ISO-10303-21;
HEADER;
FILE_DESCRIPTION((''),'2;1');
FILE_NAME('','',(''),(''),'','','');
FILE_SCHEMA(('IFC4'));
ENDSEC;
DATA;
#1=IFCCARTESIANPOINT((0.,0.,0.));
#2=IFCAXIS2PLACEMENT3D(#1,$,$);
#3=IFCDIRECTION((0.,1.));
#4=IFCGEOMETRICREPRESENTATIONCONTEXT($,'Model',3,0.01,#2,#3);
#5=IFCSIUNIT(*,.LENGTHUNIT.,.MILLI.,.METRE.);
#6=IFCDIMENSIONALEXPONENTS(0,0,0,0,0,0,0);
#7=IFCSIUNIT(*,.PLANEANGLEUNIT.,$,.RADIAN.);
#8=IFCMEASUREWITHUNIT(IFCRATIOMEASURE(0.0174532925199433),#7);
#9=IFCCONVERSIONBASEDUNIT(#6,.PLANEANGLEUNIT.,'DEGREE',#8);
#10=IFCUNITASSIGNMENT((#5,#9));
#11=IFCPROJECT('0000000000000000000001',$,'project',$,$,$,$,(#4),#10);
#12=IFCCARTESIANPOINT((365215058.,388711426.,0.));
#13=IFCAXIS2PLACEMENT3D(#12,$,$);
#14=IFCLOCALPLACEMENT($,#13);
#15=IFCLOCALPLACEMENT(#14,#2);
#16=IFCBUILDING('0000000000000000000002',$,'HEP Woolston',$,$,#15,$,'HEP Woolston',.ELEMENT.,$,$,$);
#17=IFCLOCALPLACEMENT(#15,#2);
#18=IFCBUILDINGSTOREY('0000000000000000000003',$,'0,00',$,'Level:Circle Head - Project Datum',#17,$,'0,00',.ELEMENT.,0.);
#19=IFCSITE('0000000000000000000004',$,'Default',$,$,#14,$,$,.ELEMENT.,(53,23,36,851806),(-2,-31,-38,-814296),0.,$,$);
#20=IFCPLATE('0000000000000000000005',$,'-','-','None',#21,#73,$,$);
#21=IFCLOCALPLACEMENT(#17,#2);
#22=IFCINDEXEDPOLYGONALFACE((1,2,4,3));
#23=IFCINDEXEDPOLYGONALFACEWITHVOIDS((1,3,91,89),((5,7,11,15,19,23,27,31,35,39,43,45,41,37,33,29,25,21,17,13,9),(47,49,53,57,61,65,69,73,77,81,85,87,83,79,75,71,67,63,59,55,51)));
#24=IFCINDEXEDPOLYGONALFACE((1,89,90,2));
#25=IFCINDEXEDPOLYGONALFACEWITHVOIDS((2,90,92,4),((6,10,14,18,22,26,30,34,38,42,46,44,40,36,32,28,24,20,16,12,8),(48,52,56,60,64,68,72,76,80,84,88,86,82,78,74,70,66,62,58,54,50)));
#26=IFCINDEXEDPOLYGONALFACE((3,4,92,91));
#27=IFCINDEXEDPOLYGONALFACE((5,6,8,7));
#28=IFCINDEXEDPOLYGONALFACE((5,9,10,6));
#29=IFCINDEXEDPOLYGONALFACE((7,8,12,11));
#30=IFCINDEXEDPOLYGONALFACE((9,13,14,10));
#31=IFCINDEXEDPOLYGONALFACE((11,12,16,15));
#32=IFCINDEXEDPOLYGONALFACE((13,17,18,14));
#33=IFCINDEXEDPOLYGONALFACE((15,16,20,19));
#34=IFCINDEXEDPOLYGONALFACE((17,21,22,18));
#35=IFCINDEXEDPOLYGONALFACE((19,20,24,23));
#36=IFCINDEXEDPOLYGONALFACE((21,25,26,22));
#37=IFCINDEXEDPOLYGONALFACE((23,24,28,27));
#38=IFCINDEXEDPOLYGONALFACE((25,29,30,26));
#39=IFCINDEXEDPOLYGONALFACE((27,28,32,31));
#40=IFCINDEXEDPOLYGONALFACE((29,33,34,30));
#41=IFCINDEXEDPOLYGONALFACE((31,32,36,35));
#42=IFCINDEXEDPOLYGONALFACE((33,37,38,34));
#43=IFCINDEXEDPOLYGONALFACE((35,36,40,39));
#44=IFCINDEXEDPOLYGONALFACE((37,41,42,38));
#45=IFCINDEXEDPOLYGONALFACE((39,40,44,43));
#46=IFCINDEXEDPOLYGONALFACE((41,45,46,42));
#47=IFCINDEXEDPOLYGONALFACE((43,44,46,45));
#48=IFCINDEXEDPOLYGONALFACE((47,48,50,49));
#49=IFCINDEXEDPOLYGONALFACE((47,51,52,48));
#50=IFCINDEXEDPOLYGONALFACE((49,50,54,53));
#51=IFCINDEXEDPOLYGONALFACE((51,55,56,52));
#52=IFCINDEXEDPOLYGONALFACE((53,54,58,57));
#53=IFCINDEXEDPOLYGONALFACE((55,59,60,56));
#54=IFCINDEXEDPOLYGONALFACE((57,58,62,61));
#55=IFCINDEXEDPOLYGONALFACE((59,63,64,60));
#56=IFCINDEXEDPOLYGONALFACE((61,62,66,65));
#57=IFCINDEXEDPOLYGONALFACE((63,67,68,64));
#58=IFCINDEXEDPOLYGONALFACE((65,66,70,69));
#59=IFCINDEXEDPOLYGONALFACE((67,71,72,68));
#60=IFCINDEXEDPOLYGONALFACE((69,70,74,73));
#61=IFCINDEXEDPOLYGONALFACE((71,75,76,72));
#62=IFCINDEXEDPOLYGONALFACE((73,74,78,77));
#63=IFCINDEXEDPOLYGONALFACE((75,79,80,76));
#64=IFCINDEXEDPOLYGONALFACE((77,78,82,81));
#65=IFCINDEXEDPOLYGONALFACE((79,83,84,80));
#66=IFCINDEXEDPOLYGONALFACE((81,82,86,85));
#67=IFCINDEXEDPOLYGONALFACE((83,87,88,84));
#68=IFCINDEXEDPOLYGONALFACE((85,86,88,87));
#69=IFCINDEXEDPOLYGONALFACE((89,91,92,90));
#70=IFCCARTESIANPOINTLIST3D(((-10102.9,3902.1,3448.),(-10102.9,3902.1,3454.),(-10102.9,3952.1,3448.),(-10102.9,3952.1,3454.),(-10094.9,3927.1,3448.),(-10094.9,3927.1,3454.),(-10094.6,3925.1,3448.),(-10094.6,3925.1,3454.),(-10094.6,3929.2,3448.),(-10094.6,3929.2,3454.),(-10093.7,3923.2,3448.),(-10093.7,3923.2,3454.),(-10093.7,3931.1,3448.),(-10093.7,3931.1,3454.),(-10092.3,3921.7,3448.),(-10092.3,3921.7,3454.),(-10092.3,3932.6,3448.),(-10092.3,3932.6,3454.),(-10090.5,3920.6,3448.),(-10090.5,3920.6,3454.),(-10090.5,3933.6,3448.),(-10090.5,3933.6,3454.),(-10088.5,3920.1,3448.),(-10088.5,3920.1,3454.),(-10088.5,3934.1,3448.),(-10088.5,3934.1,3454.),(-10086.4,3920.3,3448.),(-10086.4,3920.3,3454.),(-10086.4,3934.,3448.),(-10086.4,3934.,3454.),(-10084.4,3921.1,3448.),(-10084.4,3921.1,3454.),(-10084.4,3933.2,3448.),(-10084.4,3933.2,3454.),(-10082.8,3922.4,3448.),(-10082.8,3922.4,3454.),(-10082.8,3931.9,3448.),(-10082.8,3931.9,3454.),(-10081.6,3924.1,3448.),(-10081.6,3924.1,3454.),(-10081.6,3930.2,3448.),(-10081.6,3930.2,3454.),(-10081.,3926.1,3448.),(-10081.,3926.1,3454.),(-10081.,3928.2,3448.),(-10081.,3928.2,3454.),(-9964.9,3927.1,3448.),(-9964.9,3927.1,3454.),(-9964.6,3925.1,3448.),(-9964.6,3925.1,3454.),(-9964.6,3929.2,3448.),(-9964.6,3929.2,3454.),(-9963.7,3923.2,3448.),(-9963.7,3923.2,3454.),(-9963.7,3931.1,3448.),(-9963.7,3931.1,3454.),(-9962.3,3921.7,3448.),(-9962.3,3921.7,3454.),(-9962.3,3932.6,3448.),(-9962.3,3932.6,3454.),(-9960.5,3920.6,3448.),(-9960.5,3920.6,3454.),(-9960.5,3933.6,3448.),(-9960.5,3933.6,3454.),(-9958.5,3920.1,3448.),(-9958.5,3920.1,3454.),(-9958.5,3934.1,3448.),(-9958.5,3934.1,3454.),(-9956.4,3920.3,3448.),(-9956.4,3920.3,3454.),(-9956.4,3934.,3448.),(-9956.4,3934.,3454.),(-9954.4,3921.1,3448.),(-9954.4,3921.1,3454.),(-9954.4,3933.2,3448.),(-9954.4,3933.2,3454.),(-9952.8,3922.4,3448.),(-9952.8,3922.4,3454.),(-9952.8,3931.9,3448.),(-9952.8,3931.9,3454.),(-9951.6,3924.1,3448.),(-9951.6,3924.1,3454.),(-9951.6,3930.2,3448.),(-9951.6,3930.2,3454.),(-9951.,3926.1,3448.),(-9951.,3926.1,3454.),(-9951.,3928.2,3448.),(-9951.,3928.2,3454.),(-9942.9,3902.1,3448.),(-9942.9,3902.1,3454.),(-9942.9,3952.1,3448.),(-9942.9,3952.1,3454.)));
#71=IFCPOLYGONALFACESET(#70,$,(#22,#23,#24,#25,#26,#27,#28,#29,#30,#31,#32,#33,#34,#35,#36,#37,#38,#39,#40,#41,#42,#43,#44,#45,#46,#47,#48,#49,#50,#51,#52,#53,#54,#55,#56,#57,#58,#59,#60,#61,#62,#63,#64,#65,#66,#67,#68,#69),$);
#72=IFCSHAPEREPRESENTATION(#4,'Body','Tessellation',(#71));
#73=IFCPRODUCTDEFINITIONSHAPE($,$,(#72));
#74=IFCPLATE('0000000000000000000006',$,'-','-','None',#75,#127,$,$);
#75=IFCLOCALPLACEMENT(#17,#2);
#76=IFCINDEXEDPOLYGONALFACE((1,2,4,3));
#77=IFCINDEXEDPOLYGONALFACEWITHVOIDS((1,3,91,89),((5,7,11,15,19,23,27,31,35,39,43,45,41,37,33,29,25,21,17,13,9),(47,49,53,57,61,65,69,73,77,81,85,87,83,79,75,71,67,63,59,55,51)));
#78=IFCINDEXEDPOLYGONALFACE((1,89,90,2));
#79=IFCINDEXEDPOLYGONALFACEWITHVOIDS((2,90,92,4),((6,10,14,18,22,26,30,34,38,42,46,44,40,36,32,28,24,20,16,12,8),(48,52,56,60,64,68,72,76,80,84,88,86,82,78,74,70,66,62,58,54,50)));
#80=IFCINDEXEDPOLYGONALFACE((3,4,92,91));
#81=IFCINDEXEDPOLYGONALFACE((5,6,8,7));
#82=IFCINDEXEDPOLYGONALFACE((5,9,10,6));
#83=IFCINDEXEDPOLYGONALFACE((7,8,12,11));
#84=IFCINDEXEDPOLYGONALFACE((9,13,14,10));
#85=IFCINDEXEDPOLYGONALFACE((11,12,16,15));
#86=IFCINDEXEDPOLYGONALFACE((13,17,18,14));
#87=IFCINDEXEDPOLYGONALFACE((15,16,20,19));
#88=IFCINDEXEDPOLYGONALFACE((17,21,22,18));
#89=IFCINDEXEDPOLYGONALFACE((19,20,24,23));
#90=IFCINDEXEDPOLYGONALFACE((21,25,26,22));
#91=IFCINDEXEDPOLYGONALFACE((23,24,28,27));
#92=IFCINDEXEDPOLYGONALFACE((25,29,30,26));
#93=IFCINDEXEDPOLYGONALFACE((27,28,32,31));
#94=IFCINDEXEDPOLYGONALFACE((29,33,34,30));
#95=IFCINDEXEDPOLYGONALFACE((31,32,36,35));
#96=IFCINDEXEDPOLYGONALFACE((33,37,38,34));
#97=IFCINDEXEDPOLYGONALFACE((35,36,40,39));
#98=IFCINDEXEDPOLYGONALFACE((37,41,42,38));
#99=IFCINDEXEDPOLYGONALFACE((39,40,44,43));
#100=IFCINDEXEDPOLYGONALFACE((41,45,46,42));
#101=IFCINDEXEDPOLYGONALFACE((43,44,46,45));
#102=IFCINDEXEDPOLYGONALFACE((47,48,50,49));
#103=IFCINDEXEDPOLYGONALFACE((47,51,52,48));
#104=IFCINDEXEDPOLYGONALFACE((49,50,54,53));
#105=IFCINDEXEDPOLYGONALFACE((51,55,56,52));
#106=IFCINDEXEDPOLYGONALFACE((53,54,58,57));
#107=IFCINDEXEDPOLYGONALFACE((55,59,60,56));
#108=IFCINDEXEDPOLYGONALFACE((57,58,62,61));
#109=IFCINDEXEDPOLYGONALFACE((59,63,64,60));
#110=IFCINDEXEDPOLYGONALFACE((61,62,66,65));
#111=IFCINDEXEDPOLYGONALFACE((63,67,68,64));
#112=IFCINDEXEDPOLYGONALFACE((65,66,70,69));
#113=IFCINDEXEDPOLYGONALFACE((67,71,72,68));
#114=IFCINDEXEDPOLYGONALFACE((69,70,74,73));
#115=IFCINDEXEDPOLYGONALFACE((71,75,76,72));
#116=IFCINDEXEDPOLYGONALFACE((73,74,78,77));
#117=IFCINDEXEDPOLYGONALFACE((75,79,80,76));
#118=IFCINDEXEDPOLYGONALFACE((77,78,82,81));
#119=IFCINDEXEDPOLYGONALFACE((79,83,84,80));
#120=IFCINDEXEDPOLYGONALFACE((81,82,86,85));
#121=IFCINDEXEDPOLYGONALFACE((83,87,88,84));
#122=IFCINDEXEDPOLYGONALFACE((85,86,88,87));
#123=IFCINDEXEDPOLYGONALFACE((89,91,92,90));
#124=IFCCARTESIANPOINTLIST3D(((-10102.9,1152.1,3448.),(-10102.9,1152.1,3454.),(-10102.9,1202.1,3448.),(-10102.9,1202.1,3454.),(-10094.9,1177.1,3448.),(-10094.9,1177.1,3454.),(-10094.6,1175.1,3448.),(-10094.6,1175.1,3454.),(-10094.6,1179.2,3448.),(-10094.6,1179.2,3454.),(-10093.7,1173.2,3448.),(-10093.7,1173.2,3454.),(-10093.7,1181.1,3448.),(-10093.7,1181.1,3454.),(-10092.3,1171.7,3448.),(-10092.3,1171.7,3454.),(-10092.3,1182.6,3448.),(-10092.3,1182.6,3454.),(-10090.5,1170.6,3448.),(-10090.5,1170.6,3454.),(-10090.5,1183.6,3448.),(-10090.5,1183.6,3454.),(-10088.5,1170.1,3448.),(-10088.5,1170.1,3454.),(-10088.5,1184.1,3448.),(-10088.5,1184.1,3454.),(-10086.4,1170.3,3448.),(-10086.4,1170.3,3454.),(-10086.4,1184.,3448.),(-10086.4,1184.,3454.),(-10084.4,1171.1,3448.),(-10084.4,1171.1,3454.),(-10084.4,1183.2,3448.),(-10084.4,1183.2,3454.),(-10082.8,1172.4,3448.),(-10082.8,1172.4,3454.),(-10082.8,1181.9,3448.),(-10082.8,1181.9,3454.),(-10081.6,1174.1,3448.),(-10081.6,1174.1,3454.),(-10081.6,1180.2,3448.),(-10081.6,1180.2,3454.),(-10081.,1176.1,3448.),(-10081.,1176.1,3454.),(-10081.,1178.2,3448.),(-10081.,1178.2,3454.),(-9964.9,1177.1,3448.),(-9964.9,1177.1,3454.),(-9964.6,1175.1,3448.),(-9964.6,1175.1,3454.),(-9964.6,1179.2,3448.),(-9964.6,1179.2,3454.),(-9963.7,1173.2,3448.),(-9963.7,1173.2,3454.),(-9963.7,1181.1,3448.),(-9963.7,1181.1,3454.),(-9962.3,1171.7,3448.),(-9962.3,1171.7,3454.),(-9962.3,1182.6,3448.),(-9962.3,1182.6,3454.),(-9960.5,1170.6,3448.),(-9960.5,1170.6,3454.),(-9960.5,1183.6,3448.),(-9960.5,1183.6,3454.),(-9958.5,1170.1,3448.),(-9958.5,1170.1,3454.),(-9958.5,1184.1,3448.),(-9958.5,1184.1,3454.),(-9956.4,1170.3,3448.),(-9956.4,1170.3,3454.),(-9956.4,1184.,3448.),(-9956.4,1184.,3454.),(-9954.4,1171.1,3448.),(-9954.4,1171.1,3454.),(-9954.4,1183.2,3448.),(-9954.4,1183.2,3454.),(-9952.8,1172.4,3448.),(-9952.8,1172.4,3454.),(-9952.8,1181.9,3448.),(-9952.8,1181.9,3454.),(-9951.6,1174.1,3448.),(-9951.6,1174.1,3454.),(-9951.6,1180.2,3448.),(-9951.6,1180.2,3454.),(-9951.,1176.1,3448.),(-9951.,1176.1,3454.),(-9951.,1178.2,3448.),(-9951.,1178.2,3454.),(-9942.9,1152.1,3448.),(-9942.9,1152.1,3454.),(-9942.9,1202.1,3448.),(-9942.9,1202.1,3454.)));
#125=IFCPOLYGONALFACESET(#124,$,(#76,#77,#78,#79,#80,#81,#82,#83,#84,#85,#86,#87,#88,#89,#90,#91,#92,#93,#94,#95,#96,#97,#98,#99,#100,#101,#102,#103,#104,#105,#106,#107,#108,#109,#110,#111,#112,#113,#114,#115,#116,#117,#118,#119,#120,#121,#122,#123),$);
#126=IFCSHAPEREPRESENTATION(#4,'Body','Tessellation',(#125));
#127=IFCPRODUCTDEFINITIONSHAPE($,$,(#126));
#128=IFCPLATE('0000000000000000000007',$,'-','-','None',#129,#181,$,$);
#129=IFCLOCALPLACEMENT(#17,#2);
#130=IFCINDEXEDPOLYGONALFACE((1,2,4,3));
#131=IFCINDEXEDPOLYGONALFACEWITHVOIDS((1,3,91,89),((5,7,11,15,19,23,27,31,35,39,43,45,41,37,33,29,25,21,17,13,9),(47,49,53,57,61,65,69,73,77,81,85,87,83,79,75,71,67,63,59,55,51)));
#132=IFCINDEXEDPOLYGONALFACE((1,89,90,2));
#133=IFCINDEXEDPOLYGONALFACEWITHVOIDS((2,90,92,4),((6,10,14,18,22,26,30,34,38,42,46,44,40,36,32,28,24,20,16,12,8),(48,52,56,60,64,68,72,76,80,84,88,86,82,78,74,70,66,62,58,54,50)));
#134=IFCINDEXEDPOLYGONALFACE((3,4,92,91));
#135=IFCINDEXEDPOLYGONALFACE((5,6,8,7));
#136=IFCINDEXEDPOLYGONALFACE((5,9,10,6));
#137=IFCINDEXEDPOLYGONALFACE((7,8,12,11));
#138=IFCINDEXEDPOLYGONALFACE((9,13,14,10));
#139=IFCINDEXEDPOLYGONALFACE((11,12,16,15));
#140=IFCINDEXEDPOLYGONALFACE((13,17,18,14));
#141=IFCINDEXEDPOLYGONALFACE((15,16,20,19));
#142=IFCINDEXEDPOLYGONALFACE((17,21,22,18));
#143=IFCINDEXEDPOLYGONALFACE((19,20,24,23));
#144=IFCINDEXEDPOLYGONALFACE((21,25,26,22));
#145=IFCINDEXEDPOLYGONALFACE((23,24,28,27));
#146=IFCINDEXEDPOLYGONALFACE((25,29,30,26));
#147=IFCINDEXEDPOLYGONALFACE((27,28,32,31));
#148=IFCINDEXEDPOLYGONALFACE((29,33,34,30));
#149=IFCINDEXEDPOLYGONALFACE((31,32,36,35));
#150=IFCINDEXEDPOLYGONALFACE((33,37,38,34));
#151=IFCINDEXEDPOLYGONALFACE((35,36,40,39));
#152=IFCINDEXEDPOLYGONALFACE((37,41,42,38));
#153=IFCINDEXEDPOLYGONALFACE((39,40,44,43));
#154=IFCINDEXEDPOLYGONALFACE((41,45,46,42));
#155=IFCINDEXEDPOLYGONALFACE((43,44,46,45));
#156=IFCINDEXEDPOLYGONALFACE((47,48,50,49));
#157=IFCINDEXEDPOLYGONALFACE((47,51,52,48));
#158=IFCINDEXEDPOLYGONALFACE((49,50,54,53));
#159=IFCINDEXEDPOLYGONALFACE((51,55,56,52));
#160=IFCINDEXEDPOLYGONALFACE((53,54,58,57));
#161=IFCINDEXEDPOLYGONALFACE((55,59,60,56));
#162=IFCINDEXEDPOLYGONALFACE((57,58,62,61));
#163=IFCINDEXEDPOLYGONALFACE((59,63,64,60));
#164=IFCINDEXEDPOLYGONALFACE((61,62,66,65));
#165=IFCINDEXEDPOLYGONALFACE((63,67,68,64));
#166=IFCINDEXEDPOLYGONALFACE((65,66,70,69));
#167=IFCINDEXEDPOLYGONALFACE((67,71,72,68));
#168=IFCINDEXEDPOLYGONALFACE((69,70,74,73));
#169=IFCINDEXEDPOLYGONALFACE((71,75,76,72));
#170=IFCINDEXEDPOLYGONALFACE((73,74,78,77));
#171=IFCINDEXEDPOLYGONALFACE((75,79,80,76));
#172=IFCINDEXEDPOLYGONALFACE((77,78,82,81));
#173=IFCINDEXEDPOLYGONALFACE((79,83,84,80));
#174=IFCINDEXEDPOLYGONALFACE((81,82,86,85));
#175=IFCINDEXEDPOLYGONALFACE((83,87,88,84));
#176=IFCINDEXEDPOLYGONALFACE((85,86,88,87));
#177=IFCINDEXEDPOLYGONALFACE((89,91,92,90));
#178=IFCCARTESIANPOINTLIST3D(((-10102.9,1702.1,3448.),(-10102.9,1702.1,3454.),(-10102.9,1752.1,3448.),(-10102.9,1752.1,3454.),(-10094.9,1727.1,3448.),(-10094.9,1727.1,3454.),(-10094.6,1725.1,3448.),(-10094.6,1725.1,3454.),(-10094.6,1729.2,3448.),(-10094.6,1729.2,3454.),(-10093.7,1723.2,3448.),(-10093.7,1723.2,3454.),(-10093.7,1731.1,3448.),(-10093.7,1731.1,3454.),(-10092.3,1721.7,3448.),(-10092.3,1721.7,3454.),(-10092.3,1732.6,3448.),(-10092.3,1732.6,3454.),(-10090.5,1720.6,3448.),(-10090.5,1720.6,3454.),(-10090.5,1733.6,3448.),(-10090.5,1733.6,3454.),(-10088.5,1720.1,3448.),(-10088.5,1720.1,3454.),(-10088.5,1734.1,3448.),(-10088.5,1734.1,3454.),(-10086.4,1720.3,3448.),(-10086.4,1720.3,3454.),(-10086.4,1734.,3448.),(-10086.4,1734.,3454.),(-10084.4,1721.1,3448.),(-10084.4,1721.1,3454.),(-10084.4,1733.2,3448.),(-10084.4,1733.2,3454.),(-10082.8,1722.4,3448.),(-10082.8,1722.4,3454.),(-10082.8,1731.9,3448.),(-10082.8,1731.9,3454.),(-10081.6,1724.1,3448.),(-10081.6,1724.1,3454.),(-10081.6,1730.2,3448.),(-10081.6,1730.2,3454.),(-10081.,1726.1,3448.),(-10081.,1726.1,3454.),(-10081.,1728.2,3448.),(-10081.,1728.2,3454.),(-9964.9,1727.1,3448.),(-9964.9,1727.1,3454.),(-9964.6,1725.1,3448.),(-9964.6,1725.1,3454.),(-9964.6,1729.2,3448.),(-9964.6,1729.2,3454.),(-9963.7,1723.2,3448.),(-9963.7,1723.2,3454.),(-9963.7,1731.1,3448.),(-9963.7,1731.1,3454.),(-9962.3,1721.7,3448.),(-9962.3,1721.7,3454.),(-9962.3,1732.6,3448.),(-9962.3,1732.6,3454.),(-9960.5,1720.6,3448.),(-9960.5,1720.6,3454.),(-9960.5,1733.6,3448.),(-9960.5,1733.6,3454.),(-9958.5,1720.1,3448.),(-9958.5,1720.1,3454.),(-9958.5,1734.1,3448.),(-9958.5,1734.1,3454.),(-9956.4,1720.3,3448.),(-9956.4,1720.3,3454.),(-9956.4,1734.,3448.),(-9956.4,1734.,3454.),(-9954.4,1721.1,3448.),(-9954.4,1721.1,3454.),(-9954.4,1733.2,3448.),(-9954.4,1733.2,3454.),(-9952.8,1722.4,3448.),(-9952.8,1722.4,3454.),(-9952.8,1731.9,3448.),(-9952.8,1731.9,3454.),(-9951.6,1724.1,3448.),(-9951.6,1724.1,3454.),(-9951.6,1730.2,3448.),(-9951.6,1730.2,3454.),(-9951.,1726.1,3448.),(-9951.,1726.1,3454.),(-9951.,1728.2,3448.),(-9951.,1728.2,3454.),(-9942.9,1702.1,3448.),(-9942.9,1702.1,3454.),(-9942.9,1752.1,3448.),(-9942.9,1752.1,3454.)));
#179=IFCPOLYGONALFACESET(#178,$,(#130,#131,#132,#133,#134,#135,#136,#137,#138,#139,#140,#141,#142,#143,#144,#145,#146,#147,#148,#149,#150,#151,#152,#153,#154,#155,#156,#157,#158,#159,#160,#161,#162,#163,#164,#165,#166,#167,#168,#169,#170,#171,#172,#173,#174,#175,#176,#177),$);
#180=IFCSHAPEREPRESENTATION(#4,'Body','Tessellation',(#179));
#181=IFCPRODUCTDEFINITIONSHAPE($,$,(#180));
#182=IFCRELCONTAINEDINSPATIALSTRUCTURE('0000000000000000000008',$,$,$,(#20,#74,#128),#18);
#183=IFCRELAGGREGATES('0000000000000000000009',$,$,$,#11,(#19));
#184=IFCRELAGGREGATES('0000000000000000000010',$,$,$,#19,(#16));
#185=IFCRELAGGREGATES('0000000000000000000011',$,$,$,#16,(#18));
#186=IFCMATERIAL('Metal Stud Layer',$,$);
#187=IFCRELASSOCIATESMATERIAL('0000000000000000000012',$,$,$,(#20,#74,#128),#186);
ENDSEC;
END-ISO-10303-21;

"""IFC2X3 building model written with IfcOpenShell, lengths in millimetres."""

from ifc_helpers import new_model, entity, si_unit, converted_unit, direction, frame, frame_2d, origin, origin_with_axes, place, context, project, spatial, polyline, circle, outline, extrude, material, element, save


model = new_model("IFC2X3")

# Units and contexts
model_context = context("Model", 3, precision=0.01, world=origin(), true_north=direction((0.0, 1.0)))
ifc_project = project(units=[si_unit("LENGTHUNIT", "METRE", prefix="MILLI"), converted_unit("PLANEANGLEUNIT", "DEGREE", entity("IfcRatioMeasure", 0.0174532925199433), si_unit("PLANEANGLEUNIT", "RADIAN"), dimensions=[0, 0, 0, 0, 0, 0, 0])], contexts=[model_context])

# Site, building, storey
site_placement = place(None, frame((365215058.0, 388711426.0, 0.0)))
site = spatial("IfcSite", under=ifc_project, at=site_placement, Name="Default", CompositionType="ELEMENT", RefLatitude=(53, 23, 36, 851806), RefLongitude=(-2, -31, -38, -814296), RefElevation=0.0)
building_placement = place(site_placement, origin())
building = spatial("IfcBuilding", under=site, at=building_placement, Name="HEP Woolston", LongName="HEP Woolston", CompositionType="ELEMENT")
storey_placement = place(building_placement, origin())
storey = spatial("IfcBuildingStorey", under=building, at=storey_placement, Name="0,00", ObjectType="Level:Circle Head - Project Datum", LongName="0,00", CompositionType="ELEMENT", Elevation=0.0)

# Plates, openings
ifc_material = material(Name="Metal Stud Layer")
plate_1_placement = place(storey_placement, frame((-9942.9, 3902.1, 3454.0), z_axis=(0.0, 0.0, -1.0), x_axis=(-1.0, 0.0, 0.0)))
plate_1 = element("IfcPlate", 1, at=plate_1_placement, inside=storey, material=ifc_material, Name="-", Description="-", ObjectType="None", context=model_context, shape_type="SweptSolid", body=[
    extrude(outline(polyline([(160.0, 0.0), (160.0, 50.0), (0.0, 50.0), (0.0, 0.0), (160.0, 0.0)])), origin_with_axes(), (0.0, 0.0, 1.0), 6.0),
])
opening_1_placement = place(plate_1_placement, frame((80.0, 25.0, 6.5), z_axis=(0.0, 0.0, -1.0), x_axis=(1.0, 0.0, 0.0)))
element("IfcOpeningElement", 2, at=opening_1_placement, cuts=plate_1, ObjectType="Opening", context=model_context, shape_type="SweptSolid", body=[
    extrude(circle(Radius=7.0, at=frame_2d((65.0, 0.0), x_axis=(1.0, 0.0))), origin(), (0.0, 0.0, 1.0), 7.0),
])
opening_2_placement = place(plate_1_placement, frame((80.0, 25.0, 6.5), z_axis=(0.0, 0.0, -1.0), x_axis=(1.0, 0.0, 0.0)))
element("IfcOpeningElement", 3, at=opening_2_placement, cuts=plate_1, ObjectType="Opening", context=model_context, shape_type="SweptSolid", body=[
    extrude(circle(Radius=7.0, at=frame_2d((-65.0, 0.0), x_axis=(1.0, 0.0))), origin(), (0.0, 0.0, 1.0), 7.0),
])
plate_2_placement = place(storey_placement, frame((-9942.9, 1152.1, 3454.0), z_axis=(0.0, 0.0, -1.0), x_axis=(-1.0, 0.0, 0.0)))
plate_2 = element("IfcPlate", 4, at=plate_2_placement, inside=storey, material=ifc_material, Name="-", Description="-", ObjectType="None", context=model_context, shape_type="SweptSolid", body=[
    extrude(outline(polyline([(160.0, 0.0), (160.0, 50.0), (0.0, 50.0), (0.0, 0.0), (160.0, 0.0)])), origin_with_axes(), (0.0, 0.0, 1.0), 6.0),
])
opening_3_placement = place(plate_2_placement, frame((80.0, 25.0, 6.5), z_axis=(0.0, 0.0, -1.0), x_axis=(1.0, 0.0, 0.0)))
element("IfcOpeningElement", 5, at=opening_3_placement, cuts=plate_2, ObjectType="Opening", context=model_context, shape_type="SweptSolid", body=[
    extrude(circle(Radius=7.0, at=frame_2d((65.0, 0.0), x_axis=(1.0, 0.0))), origin(), (0.0, 0.0, 1.0), 7.0),
])
opening_4_placement = place(plate_2_placement, frame((80.0, 25.0, 6.5), z_axis=(0.0, 0.0, -1.0), x_axis=(1.0, 0.0, 0.0)))
element("IfcOpeningElement", 6, at=opening_4_placement, cuts=plate_2, ObjectType="Opening", context=model_context, shape_type="SweptSolid", body=[
    extrude(circle(Radius=7.0, at=frame_2d((-65.0, 0.0), x_axis=(1.0, 0.0))), origin(), (0.0, 0.0, 1.0), 7.0),
])
plate_3_placement = place(storey_placement, frame((-9942.9, 1702.1, 3454.0), z_axis=(0.0, 0.0, -1.0), x_axis=(-1.0, 0.0, 0.0)))
plate_3 = element("IfcPlate", 7, at=plate_3_placement, inside=storey, material=ifc_material, Name="-", Description="-", ObjectType="None", context=model_context, shape_type="SweptSolid", body=[
    extrude(outline(polyline([(160.0, 0.0), (160.0, 50.0), (0.0, 50.0), (0.0, 0.0), (160.0, 0.0)])), origin_with_axes(), (0.0, 0.0, 1.0), 6.0),
])
opening_5_placement = place(plate_3_placement, frame((80.0, 25.0, 6.5), z_axis=(0.0, 0.0, -1.0), x_axis=(1.0, 0.0, 0.0)))
element("IfcOpeningElement", 8, at=opening_5_placement, cuts=plate_3, ObjectType="Opening", context=model_context, shape_type="SweptSolid", body=[
    extrude(circle(Radius=7.0, at=frame_2d((65.0, 0.0), x_axis=(1.0, 0.0))), origin(), (0.0, 0.0, 1.0), 7.0),
])
opening_6_placement = place(plate_3_placement, frame((80.0, 25.0, 6.5), z_axis=(0.0, 0.0, -1.0), x_axis=(1.0, 0.0, 0.0)))
element("IfcOpeningElement", 9, at=opening_6_placement, cuts=plate_3, ObjectType="Opening", context=model_context, shape_type="SweptSolid", body=[
    extrude(circle(Radius=7.0, at=frame_2d((-65.0, 0.0), x_axis=(1.0, 0.0))), origin(), (0.0, 0.0, 1.0), 7.0),
])

save(model, "model.ifc")
